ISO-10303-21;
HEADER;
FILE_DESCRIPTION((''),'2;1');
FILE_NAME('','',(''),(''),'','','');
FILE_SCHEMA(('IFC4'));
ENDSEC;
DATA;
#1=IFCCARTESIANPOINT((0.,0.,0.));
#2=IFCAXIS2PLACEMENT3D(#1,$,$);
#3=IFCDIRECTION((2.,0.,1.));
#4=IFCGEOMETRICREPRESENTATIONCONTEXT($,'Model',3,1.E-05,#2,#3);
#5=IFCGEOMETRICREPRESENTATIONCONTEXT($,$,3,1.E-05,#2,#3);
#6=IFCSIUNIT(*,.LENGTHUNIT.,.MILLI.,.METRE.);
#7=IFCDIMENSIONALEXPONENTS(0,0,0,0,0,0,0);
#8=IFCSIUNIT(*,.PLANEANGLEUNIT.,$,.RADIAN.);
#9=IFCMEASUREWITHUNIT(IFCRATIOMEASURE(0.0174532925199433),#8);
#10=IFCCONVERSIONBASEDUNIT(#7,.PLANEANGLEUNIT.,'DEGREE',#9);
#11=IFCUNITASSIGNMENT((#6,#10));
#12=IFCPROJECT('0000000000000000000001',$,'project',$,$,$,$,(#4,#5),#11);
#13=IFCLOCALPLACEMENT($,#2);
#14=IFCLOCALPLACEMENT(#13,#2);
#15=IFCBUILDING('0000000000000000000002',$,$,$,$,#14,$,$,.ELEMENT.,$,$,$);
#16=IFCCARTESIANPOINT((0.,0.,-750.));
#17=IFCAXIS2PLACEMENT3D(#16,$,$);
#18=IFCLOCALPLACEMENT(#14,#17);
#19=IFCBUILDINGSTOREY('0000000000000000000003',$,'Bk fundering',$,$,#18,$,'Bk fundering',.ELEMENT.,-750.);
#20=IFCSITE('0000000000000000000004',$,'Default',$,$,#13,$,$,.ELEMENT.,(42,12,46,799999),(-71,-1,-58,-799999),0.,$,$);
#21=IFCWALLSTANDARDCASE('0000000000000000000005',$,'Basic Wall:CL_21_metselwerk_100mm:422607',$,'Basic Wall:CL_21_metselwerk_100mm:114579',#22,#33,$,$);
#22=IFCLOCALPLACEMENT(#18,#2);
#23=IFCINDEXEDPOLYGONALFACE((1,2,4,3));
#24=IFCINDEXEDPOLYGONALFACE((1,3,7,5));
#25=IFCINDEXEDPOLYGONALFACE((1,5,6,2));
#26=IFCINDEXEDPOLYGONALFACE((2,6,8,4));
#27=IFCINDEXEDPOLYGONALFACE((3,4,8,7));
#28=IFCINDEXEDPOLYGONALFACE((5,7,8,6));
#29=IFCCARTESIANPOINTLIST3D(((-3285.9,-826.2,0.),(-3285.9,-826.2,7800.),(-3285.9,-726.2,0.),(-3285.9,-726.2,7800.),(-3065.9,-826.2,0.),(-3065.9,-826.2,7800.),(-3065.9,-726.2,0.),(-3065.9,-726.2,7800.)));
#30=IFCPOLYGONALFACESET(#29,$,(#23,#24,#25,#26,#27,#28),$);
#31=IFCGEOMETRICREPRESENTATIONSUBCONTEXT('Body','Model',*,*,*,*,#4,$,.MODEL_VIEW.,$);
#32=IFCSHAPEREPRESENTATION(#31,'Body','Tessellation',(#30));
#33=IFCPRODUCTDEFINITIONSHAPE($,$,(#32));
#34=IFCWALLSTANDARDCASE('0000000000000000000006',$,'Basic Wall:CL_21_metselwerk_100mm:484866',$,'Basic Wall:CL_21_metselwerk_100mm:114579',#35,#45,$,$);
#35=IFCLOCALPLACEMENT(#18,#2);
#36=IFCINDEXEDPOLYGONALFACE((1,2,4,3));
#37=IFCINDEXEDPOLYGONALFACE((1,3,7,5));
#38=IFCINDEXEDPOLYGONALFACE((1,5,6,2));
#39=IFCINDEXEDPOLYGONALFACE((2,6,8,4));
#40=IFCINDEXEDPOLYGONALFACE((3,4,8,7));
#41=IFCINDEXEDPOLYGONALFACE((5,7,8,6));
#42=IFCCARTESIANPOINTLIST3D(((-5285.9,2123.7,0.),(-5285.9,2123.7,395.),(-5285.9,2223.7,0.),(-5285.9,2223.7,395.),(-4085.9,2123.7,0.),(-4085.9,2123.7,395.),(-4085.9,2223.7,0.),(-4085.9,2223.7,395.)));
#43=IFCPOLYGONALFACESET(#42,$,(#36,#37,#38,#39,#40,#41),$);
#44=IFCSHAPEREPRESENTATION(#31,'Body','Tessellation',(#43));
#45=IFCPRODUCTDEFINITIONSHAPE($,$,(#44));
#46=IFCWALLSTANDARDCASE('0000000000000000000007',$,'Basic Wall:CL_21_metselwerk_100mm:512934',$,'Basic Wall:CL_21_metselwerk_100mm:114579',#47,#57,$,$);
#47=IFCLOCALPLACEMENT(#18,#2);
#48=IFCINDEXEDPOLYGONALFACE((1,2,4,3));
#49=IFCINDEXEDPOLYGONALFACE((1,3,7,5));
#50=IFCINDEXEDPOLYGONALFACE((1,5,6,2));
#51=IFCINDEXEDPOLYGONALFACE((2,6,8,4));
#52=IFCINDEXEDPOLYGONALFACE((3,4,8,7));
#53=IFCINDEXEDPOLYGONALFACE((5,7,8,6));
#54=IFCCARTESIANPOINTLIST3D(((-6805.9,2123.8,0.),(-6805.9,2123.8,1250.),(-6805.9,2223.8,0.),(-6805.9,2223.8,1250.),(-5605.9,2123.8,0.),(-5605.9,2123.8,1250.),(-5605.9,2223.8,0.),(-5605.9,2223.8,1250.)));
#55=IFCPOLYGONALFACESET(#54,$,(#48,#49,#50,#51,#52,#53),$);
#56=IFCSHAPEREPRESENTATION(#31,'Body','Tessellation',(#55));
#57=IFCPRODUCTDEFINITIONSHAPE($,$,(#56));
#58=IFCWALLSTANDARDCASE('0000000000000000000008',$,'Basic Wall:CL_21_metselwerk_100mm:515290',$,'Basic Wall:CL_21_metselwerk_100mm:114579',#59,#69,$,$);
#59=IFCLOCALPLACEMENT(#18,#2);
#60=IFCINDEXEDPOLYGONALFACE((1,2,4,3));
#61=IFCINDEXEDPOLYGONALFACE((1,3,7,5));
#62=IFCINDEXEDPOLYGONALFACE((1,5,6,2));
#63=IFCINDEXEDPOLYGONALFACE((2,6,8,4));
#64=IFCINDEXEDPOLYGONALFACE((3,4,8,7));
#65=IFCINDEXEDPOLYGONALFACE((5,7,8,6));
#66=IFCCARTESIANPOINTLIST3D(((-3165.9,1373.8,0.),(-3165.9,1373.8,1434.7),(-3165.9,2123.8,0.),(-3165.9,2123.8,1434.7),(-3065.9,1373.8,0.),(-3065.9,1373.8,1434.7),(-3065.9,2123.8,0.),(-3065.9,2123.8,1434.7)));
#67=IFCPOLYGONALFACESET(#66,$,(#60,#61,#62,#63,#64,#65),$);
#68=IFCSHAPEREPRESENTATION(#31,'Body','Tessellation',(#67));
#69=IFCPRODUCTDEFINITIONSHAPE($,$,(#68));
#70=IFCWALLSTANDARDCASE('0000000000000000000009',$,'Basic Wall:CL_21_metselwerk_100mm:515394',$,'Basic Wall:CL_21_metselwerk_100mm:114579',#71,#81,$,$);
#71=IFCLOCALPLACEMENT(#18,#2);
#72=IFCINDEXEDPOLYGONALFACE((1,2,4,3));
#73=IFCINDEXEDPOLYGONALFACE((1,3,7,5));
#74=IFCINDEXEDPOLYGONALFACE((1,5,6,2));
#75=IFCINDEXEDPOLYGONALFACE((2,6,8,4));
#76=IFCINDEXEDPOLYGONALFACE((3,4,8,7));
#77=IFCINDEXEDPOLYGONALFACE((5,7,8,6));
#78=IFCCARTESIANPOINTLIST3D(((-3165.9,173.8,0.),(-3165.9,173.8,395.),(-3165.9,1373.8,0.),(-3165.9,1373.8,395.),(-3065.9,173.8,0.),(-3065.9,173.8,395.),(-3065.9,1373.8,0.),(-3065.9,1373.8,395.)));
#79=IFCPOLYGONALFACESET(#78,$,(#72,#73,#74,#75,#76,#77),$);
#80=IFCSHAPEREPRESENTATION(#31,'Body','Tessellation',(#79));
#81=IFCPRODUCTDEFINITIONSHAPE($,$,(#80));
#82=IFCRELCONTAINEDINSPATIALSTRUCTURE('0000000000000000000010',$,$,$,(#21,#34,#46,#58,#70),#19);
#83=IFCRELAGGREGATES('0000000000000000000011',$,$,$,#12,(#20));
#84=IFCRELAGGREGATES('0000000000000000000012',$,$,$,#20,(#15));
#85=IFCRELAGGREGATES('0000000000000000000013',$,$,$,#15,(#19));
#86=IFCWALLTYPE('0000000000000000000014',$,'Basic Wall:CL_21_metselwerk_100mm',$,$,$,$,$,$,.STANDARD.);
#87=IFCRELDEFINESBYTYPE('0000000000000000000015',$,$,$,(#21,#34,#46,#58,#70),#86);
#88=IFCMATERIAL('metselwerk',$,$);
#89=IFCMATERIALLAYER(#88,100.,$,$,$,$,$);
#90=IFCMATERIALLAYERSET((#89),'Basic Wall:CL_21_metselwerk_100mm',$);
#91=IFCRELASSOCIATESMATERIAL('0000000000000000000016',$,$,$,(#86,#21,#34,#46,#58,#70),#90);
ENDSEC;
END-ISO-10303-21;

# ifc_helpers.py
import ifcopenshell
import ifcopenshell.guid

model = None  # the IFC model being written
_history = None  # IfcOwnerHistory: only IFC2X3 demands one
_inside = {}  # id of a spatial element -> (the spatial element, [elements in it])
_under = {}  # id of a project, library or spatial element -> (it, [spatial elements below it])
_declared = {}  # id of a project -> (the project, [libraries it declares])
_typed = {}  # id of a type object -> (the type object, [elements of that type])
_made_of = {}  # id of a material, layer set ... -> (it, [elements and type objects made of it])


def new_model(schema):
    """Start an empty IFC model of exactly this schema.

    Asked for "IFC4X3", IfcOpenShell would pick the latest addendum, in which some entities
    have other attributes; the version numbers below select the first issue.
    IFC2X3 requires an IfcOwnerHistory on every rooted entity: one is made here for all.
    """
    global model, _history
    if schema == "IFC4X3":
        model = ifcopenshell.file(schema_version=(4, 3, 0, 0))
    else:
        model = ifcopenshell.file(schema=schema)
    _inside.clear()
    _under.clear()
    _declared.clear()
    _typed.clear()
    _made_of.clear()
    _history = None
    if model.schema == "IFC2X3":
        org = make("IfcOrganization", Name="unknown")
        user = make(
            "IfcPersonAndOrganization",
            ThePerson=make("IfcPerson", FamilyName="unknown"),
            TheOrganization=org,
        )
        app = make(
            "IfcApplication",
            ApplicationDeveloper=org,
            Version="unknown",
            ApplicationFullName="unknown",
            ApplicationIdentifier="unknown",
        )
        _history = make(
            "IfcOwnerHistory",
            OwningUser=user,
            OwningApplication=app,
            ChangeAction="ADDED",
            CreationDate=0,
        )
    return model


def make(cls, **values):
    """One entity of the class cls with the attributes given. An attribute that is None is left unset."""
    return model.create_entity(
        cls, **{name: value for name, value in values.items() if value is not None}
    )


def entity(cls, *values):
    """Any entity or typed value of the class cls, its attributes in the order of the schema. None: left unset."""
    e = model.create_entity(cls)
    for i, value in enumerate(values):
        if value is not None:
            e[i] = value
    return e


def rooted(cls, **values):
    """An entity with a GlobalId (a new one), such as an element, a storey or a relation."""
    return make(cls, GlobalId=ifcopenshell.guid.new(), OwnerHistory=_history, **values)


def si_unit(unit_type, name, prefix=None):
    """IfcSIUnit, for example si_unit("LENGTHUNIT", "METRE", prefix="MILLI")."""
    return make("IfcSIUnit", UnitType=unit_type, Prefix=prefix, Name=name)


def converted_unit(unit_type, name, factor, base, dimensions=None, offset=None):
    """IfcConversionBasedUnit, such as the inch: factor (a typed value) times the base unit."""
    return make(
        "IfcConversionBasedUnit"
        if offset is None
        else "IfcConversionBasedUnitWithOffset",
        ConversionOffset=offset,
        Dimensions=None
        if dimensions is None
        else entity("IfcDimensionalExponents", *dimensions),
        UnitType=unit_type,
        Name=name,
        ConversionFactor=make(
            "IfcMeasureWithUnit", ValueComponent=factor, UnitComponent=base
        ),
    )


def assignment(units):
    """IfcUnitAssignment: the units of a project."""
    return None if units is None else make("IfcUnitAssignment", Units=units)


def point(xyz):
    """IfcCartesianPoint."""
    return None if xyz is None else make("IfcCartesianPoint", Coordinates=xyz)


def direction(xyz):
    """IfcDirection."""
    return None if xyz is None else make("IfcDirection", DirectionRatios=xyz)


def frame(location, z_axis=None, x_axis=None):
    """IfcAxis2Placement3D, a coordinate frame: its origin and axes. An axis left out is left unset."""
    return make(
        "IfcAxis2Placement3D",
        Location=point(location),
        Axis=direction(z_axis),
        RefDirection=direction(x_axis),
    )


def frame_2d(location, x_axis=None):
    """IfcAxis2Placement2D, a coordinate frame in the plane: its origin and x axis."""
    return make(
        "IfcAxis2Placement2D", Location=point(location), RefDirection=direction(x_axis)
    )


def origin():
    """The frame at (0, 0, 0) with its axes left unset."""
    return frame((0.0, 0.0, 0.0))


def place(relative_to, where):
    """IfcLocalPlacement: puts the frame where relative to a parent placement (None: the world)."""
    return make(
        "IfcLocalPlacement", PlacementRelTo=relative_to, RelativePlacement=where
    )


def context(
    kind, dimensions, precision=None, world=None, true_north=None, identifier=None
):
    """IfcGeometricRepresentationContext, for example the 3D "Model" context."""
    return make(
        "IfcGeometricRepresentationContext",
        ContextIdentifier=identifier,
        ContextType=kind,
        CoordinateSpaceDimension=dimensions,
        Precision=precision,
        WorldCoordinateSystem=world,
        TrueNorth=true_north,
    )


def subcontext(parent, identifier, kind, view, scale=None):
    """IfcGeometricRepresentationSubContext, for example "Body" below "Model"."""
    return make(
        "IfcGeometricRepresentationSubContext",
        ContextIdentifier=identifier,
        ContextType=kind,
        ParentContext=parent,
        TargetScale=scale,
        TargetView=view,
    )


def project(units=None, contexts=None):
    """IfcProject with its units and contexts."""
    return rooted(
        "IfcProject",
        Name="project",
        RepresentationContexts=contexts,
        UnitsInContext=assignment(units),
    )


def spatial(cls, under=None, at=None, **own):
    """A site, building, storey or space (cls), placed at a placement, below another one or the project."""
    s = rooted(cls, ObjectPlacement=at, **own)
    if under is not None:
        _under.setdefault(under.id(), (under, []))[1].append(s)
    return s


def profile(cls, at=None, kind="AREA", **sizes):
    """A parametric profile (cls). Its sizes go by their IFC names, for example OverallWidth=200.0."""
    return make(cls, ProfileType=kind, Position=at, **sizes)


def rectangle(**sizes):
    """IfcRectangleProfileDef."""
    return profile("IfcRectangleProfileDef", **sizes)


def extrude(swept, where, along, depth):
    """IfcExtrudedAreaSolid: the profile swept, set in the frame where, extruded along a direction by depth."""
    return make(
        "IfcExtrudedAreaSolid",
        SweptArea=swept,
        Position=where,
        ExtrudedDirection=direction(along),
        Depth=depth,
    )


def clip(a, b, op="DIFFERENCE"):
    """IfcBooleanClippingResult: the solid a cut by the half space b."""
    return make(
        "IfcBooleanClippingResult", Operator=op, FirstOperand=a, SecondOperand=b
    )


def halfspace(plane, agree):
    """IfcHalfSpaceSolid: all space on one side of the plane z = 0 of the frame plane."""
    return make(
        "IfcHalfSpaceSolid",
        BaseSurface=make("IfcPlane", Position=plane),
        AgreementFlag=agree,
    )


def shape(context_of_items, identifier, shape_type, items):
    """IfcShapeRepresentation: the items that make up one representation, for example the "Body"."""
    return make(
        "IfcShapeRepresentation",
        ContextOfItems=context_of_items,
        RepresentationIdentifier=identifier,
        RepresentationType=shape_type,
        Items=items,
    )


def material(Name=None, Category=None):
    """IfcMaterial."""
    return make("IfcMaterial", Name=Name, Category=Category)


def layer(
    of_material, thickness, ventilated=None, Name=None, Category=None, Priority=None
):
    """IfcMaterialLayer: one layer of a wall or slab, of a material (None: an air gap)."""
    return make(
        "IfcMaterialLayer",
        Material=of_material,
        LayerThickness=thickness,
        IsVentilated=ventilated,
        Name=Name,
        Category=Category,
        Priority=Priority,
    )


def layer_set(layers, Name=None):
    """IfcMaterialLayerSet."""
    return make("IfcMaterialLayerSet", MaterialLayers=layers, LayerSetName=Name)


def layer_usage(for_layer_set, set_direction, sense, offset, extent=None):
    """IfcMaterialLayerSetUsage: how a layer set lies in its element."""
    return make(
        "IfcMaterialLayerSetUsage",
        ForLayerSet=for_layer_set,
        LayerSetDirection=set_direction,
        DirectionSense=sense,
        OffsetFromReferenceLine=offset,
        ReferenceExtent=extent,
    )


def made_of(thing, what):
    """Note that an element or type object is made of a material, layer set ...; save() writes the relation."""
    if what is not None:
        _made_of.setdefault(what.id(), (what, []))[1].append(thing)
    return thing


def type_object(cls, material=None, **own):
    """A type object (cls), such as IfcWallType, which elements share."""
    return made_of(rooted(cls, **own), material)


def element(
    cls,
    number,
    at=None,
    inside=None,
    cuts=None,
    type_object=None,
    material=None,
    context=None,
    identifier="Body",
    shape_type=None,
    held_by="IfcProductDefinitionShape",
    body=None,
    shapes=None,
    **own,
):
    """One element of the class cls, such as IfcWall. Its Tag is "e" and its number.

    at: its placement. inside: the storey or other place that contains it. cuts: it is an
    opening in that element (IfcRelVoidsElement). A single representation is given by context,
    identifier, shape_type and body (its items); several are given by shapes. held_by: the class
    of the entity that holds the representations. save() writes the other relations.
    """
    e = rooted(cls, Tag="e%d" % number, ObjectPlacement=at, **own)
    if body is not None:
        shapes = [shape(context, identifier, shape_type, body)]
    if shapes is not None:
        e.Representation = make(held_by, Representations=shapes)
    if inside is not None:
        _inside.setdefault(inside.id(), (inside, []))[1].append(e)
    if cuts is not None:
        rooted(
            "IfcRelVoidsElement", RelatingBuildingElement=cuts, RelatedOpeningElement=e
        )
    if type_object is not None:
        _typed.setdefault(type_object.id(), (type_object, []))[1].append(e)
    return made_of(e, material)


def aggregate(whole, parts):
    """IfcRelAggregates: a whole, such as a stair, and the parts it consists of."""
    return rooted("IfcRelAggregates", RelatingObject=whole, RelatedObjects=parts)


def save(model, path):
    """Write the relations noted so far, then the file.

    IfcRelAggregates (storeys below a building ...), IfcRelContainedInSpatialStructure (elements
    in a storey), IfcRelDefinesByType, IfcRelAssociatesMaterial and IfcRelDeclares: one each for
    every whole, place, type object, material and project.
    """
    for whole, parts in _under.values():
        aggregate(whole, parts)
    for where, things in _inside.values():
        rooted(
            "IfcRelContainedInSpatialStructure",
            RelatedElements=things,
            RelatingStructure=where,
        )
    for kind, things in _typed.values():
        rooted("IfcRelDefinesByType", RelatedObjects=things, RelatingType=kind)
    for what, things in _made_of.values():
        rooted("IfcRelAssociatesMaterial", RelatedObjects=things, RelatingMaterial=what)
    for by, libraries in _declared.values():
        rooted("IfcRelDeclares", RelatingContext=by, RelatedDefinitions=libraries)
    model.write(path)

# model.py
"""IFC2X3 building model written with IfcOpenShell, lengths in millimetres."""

from ifc_helpers import new_model, entity, si_unit, converted_unit, direction, frame, frame_2d, origin, place, context, subcontext, project, spatial, rectangle, extrude, clip, halfspace, material, layer, layer_set, layer_usage, type_object, element, save


model = new_model("IFC2X3")

# Units and contexts
model_context = context("Model", 3, precision=1e-05, world=origin(), true_north=direction((2.0, 0.0, 1.0)))
context_of_model = context(None, 3, precision=1e-05, world=origin(), true_north=direction((2.0, 0.0, 1.0)))
body_context = subcontext(model_context, "Body", "Model", "MODEL_VIEW")
ifc_project = project(units=[si_unit("LENGTHUNIT", "METRE", prefix="MILLI"), converted_unit("PLANEANGLEUNIT", "DEGREE", entity("IfcRatioMeasure", 0.0174532925199433), si_unit("PLANEANGLEUNIT", "RADIAN"), dimensions=[0, 0, 0, 0, 0, 0, 0])], contexts=[model_context, context_of_model])

# Site, building, storey
site_placement = place(None, origin())
site = spatial("IfcSite", under=ifc_project, at=site_placement, Name="Default", CompositionType="ELEMENT", RefLatitude=(42, 12, 46, 799999), RefLongitude=(-71, -1, -58, -799999), RefElevation=0.0)
building_placement = place(site_placement, origin())
building = spatial("IfcBuilding", under=site, at=building_placement, CompositionType="ELEMENT")
storey_placement = place(building_placement, frame((0.0, 0.0, -750.0)))
storey = spatial("IfcBuildingStorey", under=building, at=storey_placement, Name="Bk fundering", LongName="Bk fundering", CompositionType="ELEMENT", Elevation=-750.0)

# Walls
ifc_material_1 = material(Name="metselwerk")
ifc_layer_1 = layer(ifc_material_1, 100.0)
ifc_layer_set_1 = layer_set([ifc_layer_1], Name="Basic Wall:CL_21_metselwerk_100mm")
wall_type_1 = type_object("IfcWallType", Name="Basic Wall:CL_21_metselwerk_100mm", PredefinedType="STANDARD", material=ifc_layer_set_1)
ifc_layer_usage_1 = layer_usage(ifc_layer_set_1, "AXIS2", "NEGATIVE", 50.0)
wall_1_placement = place(storey_placement, frame((-3065.9, -776.2, 0.0), z_axis=(0.0, 0.0, 1.0), x_axis=(-1.0, 0.0, 0.0)))
element("IfcWallStandardCase", 1, at=wall_1_placement, inside=storey, type_object=wall_type_1, material=ifc_layer_usage_1, Name="Basic Wall:CL_21_metselwerk_100mm:422607", ObjectType="Basic Wall:CL_21_metselwerk_100mm:114579", context=body_context, shape_type="SweptSolid", body=[
    extrude(rectangle(XDim=220.0, YDim=100.0, at=frame_2d((110.0, 0.0), x_axis=(-1.0, 0.0))), origin(), (0.0, 0.0, 1.0), 7800.0),
])
ifc_layer_usage_2 = layer_usage(ifc_layer_set_1, "AXIS2", "NEGATIVE", 50.0)
wall_2_placement = place(storey_placement, frame((-5285.9, 2173.7, 0.0)))
element("IfcWallStandardCase", 2, at=wall_2_placement, inside=storey, type_object=wall_type_1, material=ifc_layer_usage_2, Name="Basic Wall:CL_21_metselwerk_100mm:484866", ObjectType="Basic Wall:CL_21_metselwerk_100mm:114579", context=body_context, shape_type="Clipping", body=[
    clip(extrude(rectangle(XDim=1200.0, YDim=100.0, at=frame_2d((600.0, 0.0), x_axis=(-1.0, 0.0))), origin(), (0.0, 0.0, 1.0), 1250.0), halfspace(frame((0.0, -50.0, 395.0), z_axis=(0.0, 0.0, 1.0), x_axis=(0.0, 1.0, 0.0)), False)),
])
ifc_layer_usage_3 = layer_usage(ifc_layer_set_1, "AXIS2", "NEGATIVE", 50.0)
wall_3_placement = place(storey_placement, frame((-6805.9, 2173.8, 0.0)))
element("IfcWallStandardCase", 3, at=wall_3_placement, inside=storey, type_object=wall_type_1, material=ifc_layer_usage_3, Name="Basic Wall:CL_21_metselwerk_100mm:512934", ObjectType="Basic Wall:CL_21_metselwerk_100mm:114579", context=body_context, shape_type="SweptSolid", body=[
    extrude(rectangle(XDim=1200.0, YDim=100.0, at=frame_2d((600.0, 0.0), x_axis=(-1.0, 0.0))), origin(), (0.0, 0.0, 1.0), 1250.0),
])
ifc_layer_usage_4 = layer_usage(ifc_layer_set_1, "AXIS2", "NEGATIVE", 50.0)
wall_4_placement = place(storey_placement, frame((-3115.9, 2123.8, 0.0), z_axis=(0.0, 0.0, 1.0), x_axis=(0.0, -1.0, 0.0)))
element("IfcWallStandardCase", 4, at=wall_4_placement, inside=storey, type_object=wall_type_1, material=ifc_layer_usage_4, Name="Basic Wall:CL_21_metselwerk_100mm:515290", ObjectType="Basic Wall:CL_21_metselwerk_100mm:114579", context=body_context, shape_type="SweptSolid", body=[
    extrude(rectangle(XDim=750.0, YDim=100.0, at=frame_2d((375.0, 0.0), x_axis=(-1.0, 0.0))), origin(), (0.0, 0.0, 1.0), 1434.7),
])
ifc_layer_usage_5 = layer_usage(ifc_layer_set_1, "AXIS2", "NEGATIVE", 50.0)
wall_5_placement = place(storey_placement, frame((-3115.9, 1373.8, 0.0), z_axis=(0.0, 0.0, 1.0), x_axis=(0.0, -1.0, 0.0)))
element("IfcWallStandardCase", 5, at=wall_5_placement, inside=storey, type_object=wall_type_1, material=ifc_layer_usage_5, Name="Basic Wall:CL_21_metselwerk_100mm:515394", ObjectType="Basic Wall:CL_21_metselwerk_100mm:114579", context=body_context, shape_type="SweptSolid", body=[
    extrude(rectangle(XDim=1200.0, YDim=100.0, at=frame_2d((600.0, 0.0), x_axis=(-1.0, 0.0))), origin(), (0.0, 0.0, 1.0), 395.0),
])

save(model, "model.ifc")
